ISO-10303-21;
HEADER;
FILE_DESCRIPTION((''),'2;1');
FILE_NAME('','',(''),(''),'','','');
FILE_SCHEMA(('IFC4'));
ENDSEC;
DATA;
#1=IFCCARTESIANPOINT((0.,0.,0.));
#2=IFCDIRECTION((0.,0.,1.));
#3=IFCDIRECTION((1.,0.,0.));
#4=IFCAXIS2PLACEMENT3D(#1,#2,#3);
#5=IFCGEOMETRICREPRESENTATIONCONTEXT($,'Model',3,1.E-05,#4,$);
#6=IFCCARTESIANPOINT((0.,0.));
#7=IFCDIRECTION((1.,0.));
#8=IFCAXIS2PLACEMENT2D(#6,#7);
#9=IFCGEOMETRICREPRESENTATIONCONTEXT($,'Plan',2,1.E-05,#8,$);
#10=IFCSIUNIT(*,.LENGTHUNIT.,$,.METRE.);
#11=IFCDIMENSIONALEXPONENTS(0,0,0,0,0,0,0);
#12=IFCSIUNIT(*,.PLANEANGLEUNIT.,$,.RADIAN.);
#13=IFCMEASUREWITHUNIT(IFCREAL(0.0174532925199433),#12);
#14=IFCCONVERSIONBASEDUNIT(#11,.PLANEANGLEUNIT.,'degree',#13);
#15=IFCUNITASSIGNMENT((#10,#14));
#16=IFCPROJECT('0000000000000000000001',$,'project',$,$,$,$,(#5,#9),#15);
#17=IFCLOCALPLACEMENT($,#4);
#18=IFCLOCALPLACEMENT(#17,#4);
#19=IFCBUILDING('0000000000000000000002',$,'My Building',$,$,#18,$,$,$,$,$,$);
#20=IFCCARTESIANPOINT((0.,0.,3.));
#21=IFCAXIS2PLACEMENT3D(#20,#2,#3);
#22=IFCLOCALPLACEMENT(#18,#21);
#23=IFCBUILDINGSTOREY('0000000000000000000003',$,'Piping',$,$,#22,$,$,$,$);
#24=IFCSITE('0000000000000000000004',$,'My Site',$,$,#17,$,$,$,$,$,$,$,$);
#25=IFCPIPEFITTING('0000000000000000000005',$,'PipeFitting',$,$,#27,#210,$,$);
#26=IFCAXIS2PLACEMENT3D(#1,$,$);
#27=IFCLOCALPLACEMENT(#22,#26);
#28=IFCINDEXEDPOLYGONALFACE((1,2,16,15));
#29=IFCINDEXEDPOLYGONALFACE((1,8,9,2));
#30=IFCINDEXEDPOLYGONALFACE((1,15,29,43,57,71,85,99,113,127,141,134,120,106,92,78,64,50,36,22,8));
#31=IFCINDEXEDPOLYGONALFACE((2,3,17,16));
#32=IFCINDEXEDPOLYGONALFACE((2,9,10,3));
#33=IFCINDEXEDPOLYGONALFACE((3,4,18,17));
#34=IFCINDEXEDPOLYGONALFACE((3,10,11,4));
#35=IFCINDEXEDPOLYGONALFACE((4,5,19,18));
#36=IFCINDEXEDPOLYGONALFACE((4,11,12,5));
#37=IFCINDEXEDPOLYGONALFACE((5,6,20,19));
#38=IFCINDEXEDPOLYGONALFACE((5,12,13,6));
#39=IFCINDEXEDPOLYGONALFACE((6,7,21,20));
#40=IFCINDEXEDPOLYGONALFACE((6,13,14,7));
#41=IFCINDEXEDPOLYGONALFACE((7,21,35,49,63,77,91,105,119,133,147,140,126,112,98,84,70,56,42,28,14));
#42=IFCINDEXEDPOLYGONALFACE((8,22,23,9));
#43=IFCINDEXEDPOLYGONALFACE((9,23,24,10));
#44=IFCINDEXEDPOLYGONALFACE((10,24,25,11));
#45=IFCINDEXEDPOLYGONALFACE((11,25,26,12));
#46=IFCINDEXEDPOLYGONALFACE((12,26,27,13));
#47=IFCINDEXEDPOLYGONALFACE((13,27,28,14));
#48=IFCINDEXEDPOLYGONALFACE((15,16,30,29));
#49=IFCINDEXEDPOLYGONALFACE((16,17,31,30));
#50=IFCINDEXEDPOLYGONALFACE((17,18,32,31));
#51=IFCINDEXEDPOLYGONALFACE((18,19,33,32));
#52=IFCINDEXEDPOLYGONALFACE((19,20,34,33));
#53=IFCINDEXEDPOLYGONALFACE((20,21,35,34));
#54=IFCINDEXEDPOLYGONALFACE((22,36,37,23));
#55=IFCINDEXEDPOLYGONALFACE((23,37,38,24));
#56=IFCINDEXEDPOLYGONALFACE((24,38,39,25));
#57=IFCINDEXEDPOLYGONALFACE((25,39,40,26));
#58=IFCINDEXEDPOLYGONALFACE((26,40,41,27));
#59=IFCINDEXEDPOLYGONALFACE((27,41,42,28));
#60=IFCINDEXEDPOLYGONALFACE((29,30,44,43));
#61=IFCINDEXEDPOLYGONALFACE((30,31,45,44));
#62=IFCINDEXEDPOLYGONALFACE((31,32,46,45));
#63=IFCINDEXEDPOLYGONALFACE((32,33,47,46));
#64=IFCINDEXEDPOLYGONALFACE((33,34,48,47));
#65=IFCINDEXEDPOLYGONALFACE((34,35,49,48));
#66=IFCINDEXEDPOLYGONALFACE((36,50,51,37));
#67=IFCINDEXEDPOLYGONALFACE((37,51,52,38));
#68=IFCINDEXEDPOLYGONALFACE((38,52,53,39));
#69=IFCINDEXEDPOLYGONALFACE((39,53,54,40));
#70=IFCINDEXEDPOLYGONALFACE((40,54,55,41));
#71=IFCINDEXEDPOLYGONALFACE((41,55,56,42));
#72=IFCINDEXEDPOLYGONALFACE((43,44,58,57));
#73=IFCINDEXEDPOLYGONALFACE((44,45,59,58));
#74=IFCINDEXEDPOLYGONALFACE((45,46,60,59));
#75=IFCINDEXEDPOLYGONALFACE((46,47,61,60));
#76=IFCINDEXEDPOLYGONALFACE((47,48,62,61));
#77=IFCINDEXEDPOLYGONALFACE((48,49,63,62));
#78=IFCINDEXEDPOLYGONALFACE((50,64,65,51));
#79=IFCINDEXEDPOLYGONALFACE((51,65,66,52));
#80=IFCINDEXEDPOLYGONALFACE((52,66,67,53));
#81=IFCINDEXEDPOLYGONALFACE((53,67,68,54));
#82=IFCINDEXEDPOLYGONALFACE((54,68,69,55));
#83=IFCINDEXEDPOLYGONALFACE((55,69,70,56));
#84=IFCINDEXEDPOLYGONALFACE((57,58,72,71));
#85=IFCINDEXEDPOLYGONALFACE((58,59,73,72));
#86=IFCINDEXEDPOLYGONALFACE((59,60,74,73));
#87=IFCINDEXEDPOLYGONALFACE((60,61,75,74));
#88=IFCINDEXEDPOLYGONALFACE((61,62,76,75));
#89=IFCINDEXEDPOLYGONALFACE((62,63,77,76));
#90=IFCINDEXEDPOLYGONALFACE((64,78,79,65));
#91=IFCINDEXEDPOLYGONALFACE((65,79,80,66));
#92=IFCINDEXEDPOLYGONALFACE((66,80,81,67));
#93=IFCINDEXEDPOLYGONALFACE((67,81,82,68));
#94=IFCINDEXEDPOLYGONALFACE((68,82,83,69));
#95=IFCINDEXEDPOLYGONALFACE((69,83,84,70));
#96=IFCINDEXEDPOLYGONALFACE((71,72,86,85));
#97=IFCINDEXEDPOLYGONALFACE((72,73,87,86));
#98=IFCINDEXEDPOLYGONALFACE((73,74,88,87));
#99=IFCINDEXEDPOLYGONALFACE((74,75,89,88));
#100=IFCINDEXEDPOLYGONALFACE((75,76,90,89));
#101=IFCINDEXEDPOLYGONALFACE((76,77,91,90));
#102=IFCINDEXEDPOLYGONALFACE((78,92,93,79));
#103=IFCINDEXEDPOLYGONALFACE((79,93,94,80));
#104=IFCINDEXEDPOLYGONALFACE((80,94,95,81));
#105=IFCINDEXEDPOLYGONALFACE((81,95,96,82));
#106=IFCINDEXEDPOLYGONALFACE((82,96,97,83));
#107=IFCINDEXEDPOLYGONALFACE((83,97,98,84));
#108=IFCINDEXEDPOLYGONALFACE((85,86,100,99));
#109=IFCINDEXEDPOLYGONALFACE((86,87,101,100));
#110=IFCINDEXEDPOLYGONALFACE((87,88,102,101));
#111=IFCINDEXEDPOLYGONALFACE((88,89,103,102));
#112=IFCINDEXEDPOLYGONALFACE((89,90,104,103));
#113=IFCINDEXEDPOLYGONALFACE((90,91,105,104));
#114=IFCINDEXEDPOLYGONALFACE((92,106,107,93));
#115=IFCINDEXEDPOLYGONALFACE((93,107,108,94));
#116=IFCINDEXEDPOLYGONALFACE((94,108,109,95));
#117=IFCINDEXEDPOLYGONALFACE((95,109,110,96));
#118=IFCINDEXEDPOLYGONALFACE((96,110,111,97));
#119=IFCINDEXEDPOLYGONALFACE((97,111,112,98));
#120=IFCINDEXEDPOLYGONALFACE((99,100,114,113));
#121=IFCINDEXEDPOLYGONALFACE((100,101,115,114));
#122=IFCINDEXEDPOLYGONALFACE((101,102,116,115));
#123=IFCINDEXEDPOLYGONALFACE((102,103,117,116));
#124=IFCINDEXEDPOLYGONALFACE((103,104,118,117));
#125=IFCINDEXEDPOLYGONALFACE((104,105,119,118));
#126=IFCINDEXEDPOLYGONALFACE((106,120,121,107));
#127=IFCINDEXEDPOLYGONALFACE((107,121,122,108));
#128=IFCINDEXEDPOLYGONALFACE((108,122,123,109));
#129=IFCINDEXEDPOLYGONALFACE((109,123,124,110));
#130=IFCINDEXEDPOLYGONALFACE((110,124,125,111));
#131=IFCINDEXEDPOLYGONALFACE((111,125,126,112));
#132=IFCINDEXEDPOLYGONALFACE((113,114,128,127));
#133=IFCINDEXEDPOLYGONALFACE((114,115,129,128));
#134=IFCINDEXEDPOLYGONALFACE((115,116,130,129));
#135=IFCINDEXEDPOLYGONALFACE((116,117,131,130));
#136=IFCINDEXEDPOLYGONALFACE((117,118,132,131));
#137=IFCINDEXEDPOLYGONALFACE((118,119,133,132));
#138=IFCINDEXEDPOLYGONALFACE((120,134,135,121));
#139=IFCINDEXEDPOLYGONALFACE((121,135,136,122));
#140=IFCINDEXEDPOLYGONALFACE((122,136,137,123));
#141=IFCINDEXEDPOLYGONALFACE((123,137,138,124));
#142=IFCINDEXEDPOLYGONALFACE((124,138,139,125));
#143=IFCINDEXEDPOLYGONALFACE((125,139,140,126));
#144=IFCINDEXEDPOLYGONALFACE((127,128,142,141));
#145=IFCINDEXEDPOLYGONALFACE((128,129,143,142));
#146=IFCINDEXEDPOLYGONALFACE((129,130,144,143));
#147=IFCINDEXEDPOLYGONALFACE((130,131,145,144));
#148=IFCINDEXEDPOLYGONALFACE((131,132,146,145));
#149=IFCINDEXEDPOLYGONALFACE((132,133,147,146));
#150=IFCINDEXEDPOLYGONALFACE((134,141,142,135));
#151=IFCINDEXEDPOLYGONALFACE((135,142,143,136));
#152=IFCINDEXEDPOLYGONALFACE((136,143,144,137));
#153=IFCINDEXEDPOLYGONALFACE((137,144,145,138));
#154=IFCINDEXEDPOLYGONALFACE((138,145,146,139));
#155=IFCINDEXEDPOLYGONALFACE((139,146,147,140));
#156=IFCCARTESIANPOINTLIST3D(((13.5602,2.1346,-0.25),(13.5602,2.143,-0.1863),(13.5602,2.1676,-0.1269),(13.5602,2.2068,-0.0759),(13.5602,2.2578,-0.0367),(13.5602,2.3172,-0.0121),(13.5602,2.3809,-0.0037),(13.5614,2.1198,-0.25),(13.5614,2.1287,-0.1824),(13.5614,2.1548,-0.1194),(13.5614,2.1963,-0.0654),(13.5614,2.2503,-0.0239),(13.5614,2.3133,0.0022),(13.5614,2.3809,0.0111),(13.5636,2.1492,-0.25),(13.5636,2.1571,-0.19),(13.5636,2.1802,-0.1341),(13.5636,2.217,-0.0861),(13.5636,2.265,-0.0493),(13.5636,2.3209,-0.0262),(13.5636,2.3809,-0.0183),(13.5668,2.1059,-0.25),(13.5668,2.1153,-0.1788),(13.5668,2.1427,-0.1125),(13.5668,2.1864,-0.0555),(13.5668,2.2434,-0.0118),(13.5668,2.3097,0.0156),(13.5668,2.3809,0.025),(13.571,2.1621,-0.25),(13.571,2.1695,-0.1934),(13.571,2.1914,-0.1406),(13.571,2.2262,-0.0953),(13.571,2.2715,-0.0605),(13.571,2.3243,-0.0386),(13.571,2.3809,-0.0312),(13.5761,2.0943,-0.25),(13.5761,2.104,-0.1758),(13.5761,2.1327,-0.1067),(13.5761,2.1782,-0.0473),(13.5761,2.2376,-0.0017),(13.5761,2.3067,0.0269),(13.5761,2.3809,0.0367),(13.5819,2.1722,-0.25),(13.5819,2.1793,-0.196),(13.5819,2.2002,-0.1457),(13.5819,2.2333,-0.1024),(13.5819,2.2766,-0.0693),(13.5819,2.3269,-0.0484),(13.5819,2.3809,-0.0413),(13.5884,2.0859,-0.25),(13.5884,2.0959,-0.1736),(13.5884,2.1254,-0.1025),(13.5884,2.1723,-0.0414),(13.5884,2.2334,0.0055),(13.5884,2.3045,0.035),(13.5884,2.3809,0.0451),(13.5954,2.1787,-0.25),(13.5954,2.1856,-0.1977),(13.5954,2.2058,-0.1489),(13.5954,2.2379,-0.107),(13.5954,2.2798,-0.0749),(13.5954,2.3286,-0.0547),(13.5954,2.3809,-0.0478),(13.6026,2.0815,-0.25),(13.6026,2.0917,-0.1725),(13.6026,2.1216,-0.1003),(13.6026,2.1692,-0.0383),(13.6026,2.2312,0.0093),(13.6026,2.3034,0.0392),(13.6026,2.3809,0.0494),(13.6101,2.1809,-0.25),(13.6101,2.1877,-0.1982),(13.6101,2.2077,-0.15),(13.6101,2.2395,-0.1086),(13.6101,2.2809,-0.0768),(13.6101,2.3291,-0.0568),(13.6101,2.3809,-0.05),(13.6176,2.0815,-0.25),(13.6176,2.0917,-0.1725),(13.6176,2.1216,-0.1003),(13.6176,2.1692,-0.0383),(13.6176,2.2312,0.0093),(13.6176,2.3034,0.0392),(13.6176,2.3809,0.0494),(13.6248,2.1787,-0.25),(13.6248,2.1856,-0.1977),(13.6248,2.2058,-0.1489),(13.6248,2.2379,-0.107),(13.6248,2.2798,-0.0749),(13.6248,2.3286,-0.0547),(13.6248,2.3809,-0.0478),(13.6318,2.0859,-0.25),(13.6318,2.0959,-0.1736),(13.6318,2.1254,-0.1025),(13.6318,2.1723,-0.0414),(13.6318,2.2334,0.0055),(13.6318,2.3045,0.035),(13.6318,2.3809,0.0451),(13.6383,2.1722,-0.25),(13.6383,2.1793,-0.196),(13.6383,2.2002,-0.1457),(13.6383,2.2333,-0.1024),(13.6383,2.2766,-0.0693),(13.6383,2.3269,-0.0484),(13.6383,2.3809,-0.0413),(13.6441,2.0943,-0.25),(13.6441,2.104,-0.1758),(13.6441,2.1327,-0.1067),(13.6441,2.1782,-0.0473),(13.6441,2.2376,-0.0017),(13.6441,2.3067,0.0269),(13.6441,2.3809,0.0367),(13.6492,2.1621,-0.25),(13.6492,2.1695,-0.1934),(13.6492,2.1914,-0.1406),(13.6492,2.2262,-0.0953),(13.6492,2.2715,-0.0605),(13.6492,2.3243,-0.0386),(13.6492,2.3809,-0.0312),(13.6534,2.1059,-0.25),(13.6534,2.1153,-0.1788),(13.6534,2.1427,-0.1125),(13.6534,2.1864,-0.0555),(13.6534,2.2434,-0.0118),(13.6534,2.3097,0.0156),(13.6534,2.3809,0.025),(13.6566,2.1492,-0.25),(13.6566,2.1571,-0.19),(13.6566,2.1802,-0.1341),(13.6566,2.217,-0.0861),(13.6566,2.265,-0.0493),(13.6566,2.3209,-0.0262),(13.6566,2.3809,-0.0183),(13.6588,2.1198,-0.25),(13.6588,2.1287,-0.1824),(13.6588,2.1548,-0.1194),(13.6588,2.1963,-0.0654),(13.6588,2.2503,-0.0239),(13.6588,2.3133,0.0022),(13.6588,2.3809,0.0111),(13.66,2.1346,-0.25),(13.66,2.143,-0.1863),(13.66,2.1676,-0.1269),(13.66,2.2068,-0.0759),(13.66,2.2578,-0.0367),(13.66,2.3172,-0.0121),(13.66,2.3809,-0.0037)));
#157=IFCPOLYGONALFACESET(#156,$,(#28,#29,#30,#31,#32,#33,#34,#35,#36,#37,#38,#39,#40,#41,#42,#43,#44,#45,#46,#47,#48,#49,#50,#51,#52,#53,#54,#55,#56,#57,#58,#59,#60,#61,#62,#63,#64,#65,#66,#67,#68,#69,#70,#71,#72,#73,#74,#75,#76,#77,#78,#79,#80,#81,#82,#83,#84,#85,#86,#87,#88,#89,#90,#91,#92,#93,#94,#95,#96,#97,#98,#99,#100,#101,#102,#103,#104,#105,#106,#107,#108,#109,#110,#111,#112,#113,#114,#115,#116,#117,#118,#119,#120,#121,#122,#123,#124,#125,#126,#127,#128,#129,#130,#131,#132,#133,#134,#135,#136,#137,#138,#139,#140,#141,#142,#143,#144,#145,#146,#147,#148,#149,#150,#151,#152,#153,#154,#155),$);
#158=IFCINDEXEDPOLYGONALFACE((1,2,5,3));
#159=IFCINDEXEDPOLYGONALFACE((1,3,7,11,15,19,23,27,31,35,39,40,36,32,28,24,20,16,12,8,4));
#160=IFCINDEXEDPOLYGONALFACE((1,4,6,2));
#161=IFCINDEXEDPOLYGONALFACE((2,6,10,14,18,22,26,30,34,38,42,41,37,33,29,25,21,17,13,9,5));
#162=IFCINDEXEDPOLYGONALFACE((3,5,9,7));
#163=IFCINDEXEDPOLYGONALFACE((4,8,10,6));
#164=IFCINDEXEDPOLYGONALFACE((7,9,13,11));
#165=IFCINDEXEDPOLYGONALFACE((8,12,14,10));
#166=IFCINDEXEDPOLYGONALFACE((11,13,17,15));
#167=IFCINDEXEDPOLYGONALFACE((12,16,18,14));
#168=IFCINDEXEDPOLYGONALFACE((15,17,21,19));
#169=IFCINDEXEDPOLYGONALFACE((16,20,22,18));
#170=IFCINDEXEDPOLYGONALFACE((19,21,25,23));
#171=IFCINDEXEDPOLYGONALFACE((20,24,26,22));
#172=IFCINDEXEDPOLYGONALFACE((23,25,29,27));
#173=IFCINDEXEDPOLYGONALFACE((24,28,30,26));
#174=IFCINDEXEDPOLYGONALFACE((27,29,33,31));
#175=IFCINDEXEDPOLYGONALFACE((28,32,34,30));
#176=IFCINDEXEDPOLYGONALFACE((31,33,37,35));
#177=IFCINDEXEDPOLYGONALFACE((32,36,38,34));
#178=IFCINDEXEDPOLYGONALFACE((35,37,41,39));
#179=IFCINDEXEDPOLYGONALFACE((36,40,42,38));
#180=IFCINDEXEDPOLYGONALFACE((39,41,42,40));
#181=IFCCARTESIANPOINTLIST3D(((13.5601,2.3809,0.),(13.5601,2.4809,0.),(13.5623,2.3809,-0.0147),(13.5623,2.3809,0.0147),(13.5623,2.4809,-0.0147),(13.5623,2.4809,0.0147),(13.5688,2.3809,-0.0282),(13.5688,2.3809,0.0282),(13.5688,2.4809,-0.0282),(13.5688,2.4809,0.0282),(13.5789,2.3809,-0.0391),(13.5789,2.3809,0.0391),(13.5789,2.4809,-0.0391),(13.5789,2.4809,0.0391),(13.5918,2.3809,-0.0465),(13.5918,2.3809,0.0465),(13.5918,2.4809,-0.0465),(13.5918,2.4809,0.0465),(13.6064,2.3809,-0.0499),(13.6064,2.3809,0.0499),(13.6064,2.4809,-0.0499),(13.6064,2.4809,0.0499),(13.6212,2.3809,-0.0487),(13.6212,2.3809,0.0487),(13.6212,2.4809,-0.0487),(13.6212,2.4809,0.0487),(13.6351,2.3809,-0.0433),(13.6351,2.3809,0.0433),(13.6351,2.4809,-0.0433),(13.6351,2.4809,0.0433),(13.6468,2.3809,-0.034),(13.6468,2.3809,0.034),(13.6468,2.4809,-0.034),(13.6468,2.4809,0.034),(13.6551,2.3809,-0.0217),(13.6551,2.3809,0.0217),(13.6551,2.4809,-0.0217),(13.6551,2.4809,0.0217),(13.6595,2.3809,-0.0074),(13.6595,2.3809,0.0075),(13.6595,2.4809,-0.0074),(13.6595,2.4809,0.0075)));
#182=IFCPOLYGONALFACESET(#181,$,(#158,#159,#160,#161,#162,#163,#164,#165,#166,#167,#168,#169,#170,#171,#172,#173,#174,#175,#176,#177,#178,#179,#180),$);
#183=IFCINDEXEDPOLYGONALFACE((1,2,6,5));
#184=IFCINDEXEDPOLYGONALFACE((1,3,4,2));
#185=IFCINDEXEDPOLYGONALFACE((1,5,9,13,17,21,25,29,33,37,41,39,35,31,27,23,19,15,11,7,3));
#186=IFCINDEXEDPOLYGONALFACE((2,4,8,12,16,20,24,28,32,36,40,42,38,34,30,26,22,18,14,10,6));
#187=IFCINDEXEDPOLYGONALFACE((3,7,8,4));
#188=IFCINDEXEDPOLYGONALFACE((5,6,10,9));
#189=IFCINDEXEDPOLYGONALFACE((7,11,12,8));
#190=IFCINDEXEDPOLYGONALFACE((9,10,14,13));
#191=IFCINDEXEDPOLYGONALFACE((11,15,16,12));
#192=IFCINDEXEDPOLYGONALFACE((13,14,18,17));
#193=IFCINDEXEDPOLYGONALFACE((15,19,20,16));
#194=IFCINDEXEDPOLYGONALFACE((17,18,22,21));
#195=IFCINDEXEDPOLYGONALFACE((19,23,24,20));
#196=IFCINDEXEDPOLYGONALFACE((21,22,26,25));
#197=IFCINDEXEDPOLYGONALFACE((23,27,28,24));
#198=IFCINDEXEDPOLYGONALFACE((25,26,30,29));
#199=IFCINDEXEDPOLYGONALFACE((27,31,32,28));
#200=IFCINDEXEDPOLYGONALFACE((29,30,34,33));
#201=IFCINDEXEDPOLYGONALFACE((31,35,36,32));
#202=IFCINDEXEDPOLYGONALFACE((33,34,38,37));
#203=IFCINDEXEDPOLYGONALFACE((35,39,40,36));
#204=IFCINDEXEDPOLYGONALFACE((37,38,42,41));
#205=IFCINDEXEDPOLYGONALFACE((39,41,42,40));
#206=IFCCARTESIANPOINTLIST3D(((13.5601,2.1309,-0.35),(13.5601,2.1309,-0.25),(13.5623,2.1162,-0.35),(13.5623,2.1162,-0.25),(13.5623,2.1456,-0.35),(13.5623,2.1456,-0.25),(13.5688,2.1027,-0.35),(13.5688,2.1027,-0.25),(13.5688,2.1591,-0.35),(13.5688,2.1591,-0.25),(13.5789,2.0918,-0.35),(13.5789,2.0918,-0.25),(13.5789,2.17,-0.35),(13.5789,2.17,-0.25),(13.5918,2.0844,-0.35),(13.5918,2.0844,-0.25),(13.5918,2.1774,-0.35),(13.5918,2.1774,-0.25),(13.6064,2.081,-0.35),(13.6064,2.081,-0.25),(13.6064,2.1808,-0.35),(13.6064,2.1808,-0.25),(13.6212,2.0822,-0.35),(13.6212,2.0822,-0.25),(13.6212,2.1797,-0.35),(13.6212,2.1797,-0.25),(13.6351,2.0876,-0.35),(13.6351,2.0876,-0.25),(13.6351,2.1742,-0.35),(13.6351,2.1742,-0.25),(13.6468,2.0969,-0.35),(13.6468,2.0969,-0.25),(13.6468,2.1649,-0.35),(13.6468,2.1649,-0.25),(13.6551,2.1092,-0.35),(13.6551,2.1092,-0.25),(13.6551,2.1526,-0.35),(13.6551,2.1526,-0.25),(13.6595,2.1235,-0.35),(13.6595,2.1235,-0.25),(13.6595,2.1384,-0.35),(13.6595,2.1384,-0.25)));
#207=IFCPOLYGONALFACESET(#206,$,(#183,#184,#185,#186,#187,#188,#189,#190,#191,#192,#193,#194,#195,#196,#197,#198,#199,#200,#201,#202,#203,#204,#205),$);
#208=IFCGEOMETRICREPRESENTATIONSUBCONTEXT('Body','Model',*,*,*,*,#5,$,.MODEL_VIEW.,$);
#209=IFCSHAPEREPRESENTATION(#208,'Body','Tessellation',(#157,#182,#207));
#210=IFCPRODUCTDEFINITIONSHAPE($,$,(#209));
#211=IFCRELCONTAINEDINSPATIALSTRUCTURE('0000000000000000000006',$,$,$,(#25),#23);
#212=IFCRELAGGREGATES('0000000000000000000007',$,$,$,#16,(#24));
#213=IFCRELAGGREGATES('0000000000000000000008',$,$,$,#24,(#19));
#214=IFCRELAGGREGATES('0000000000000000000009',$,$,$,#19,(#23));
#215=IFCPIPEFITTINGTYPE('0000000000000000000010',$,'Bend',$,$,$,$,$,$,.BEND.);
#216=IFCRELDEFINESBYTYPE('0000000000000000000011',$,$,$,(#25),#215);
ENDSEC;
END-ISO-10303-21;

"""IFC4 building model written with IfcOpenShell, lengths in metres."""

from ifc_helpers import new_model, entity, si_unit, converted_unit, frame, origin_with_axes, origin_2d_with_axis, place, context, subcontext, project, spatial, circle, extrude, source, transform, mapped, type_object, type_shapes, element, save


model = new_model("IFC4")

# Units and contexts
model_context = context("Model", 3, precision=1e-05, world=origin_with_axes())
plan_context = context("Plan", 2, precision=1e-05, world=origin_2d_with_axis())
body_context = subcontext(model_context, "Body", "Model", "MODEL_VIEW")
ifc_project = project(units=[si_unit("LENGTHUNIT", "METRE"), converted_unit("PLANEANGLEUNIT", "degree", entity("IfcReal", 0.0174532925199433), si_unit("PLANEANGLEUNIT", "RADIAN"), dimensions=[0, 0, 0, 0, 0, 0, 0])], contexts=[model_context, plan_context])

# Site, building, storey
site_placement = place(None, origin_with_axes())
site = spatial("IfcSite", under=ifc_project, at=site_placement, Name="My Site")
building_placement = place(site_placement, origin_with_axes())
building = spatial("IfcBuilding", under=site, at=building_placement, Name="My Building")
storey_placement = place(building_placement, frame((0.0, 0.0, 3.0), z_axis=(0.0, 0.0, 1.0), x_axis=(1.0, 0.0, 0.0)))
storey = spatial("IfcBuildingStorey", under=building, at=storey_placement, Name="Piping")

# Pipe fitting
pipe_fitting_type = type_object("IfcPipeFittingType", Name="Bend", PredefinedType="BEND")
shared_shape = source(origin_with_axes(), body_context, "Body", "SolidModel", [
    entity("IfcSweptDiskSolid", entity("IfcIndexedPolyCurve", entity("IfcCartesianPointList3D", [[0.0, 0.0, -0.1], [0.0, -0.0732, -0.2768], [0.0, -0.25, -0.35]]), [entity("IfcArcIndex", [1, 2, 3])]), 0.05),
    extrude(circle(Radius=0.05), origin_with_axes(), (0.0, 0.0, -1.0), 0.1),
    extrude(circle(Radius=0.05), frame((0.0, -0.25, -0.35), z_axis=(0.0, -1.0, 0.0), x_axis=(1.0, 0.0, 0.0)), (0.0, 0.0, 1.0), 0.1),
])
type_shapes(pipe_fitting_type, [shared_shape])
for number, where, z_axis, x_axis, name in (
    (1, (13.6101, 2.4809, 0.0), (0.0, 1.0, 0.0), (-1.0, 0.0, 0.0), "PipeFitting"),
):
    element("IfcPipeFitting", number, at=place(storey_placement, frame(where, z_axis=z_axis, x_axis=x_axis)), inside=storey, type_object=pipe_fitting_type, Name=name, context=body_context, shape_type="MappedRepresentation", body=[
        mapped(shared_shape, transform((0.0, 0.0, 0.0), x_axis=(1.0, 0.0, 0.0), y_axis=(0.0, 1.0, 0.0), z_axis=(0.0, 0.0, 1.0), scale=1.0)),
    ])

save(model, "model.ifc")
